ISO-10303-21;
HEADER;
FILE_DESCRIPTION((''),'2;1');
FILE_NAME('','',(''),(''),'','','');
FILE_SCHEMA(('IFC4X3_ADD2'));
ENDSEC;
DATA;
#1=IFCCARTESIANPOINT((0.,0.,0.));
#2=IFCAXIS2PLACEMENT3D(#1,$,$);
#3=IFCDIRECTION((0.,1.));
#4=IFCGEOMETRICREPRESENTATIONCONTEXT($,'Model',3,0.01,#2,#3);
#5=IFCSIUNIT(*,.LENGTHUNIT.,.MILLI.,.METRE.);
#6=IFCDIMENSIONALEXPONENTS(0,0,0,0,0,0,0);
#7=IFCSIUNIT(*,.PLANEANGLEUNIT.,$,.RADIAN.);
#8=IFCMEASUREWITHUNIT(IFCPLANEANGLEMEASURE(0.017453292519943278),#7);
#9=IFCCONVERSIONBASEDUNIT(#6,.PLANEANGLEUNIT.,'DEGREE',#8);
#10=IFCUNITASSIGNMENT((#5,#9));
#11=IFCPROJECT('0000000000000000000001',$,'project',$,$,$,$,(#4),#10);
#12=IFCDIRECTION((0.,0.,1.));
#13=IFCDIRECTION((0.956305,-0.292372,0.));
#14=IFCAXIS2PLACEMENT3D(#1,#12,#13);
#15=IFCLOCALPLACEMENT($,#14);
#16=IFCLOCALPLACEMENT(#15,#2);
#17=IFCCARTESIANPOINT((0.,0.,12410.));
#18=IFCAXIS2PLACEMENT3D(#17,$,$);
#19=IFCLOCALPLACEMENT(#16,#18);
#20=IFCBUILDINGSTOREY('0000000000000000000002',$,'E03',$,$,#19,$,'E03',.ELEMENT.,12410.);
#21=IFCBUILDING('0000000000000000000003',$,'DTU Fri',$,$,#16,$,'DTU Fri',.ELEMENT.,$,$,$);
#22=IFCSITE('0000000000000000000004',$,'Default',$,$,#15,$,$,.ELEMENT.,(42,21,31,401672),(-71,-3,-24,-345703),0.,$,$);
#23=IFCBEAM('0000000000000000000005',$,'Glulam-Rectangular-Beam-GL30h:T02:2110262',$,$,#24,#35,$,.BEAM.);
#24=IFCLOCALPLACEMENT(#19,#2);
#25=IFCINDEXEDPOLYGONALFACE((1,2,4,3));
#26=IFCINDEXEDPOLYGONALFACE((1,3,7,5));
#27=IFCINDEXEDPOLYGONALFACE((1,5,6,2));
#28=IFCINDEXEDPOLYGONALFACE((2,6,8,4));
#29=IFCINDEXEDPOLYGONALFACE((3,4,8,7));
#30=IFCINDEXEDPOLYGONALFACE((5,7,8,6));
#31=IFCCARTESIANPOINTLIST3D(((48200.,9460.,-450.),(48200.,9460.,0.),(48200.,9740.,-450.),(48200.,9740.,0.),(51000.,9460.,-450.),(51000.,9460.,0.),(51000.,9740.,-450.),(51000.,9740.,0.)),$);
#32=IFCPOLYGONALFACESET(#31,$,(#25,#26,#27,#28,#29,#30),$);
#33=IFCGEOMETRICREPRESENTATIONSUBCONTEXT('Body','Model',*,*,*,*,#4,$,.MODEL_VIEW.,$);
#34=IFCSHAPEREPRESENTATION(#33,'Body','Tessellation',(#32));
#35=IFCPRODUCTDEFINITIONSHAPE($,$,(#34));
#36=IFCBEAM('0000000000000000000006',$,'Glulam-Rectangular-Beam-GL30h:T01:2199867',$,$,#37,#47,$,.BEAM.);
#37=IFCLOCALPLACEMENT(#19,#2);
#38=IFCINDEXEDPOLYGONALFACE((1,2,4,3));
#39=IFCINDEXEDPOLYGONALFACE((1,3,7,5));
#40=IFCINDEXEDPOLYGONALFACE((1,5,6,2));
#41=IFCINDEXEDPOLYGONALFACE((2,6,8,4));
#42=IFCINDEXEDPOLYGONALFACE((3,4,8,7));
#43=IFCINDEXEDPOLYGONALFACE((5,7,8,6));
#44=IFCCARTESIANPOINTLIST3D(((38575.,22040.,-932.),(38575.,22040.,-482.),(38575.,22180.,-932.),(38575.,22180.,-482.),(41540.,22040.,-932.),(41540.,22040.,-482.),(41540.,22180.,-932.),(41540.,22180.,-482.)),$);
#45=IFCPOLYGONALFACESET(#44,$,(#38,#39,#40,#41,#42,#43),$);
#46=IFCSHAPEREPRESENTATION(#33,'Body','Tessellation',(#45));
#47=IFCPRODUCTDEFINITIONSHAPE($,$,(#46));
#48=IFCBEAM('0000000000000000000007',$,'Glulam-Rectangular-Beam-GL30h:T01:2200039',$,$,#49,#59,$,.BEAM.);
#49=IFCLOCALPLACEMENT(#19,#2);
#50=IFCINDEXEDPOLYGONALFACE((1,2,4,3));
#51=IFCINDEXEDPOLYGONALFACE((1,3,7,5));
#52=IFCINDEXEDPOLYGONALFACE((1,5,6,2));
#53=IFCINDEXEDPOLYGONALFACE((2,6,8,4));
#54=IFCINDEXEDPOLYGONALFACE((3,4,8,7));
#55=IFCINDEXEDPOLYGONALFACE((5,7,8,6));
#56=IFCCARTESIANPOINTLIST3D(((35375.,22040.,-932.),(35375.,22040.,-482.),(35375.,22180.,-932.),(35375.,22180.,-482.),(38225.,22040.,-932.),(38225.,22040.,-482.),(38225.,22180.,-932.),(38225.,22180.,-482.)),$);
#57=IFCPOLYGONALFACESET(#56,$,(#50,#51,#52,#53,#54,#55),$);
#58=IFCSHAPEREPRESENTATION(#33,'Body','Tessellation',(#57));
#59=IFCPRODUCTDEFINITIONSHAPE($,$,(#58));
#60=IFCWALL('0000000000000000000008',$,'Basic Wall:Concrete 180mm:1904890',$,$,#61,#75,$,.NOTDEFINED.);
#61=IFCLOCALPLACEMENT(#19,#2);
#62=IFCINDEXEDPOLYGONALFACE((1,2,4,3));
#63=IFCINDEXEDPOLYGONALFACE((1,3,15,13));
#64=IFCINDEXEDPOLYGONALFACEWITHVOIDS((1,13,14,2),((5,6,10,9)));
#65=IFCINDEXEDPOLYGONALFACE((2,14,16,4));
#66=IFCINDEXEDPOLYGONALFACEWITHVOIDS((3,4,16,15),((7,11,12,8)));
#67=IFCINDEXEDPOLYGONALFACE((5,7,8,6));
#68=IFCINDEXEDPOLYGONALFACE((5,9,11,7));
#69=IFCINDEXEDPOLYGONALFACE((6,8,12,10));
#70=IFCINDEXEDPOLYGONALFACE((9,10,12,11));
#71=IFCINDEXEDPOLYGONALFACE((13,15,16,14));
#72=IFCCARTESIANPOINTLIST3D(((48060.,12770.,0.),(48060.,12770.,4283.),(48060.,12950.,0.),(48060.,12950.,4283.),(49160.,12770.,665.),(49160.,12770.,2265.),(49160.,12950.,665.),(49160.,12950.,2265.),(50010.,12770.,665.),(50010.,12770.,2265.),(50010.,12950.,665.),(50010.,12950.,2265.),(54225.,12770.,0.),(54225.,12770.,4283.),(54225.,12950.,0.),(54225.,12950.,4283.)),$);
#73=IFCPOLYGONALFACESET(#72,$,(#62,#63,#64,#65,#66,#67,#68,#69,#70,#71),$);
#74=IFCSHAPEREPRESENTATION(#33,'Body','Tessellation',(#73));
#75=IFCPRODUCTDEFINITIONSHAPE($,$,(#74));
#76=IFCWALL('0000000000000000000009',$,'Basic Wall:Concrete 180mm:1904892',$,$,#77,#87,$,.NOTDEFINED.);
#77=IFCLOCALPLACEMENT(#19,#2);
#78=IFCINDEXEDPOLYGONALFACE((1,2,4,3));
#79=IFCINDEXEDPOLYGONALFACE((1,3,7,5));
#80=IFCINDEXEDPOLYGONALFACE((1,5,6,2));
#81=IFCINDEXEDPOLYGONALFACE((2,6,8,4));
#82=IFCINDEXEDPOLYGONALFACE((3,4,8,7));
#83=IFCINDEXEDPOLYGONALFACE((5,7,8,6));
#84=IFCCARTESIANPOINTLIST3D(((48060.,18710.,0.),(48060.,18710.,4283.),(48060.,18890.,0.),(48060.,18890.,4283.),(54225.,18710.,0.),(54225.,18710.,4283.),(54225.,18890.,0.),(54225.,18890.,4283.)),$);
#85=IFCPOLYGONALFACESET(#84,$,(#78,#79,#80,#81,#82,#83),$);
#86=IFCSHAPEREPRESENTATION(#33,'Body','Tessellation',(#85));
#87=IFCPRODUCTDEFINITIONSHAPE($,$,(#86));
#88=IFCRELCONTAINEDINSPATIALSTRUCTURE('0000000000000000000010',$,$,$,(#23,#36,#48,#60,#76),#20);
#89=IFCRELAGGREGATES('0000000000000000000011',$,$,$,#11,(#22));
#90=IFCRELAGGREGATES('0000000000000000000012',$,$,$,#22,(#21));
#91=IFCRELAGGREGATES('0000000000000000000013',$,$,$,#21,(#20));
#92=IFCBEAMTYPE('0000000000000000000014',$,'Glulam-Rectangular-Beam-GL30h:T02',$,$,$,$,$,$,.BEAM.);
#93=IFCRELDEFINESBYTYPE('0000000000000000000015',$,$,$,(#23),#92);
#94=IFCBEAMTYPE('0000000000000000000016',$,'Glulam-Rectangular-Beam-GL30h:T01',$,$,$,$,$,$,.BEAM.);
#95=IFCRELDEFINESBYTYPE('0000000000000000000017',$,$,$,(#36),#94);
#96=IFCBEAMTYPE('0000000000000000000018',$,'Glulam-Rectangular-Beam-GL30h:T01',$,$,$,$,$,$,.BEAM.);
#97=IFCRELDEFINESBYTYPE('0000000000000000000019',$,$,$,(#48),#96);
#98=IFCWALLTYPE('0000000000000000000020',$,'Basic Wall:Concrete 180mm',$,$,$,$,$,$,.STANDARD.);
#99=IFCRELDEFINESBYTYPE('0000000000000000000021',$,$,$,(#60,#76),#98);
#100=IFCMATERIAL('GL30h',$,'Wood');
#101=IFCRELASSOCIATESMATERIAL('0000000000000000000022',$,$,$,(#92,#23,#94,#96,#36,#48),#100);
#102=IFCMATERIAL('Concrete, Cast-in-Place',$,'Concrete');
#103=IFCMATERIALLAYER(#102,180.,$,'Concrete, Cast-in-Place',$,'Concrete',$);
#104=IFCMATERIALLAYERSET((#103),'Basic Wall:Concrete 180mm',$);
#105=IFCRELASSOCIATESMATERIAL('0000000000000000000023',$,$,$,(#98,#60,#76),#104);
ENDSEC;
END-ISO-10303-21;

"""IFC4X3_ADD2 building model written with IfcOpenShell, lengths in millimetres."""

from ifc_helpers import new_model, entity, si_unit, converted_unit, direction, frame, frame_2d, origin, origin_2d_with_axis, place, context, subcontext, project, spatial, rectangle, extrude, source, transform, mapped, material, layer, layer_set, material_profile, profile_set, profile_usage, type_object, type_shapes, element, save


model = new_model("IFC4X3_ADD2")

# Units and contexts
model_context = context("Model", 3, precision=0.01, world=origin(), true_north=direction((0.0, 1.0)))
body_context = subcontext(model_context, "Body", "Model", "MODEL_VIEW")
ifc_project = project(units=[si_unit("LENGTHUNIT", "METRE", prefix="MILLI"), converted_unit("PLANEANGLEUNIT", "DEGREE", entity("IfcPlaneAngleMeasure", 0.017453292519943278), si_unit("PLANEANGLEUNIT", "RADIAN"), dimensions=[0, 0, 0, 0, 0, 0, 0])], contexts=[model_context])

# Site, building, storey
site_placement = place(None, frame((0.0, 0.0, 0.0), z_axis=(0.0, 0.0, 1.0), x_axis=(0.956305, -0.292372, 0.0)))
site = spatial("IfcSite", under=ifc_project, at=site_placement, Name="Default", CompositionType="ELEMENT", RefLatitude=(42, 21, 31, 401672), RefLongitude=(-71, -3, -24, -345703), RefElevation=0.0)
building_placement = place(site_placement, origin())
building = spatial("IfcBuilding", under=site, at=building_placement, Name="DTU Fri", LongName="DTU Fri", CompositionType="ELEMENT")
storey_placement = place(building_placement, frame((0.0, 0.0, 12410.0)))
storey = spatial("IfcBuildingStorey", under=building, at=storey_placement, Name="E03", LongName="E03", CompositionType="ELEMENT", Elevation=12410.0)

# Shared definitions
ifc_material_1 = material(Name="GL30h", Category="Wood")

# Beams
ifc_material_profile_1 = material_profile(ifc_material_1, rectangle(XDim=450.0, YDim=280.0, at=origin_2d_with_axis()), Name="T02")
ifc_profile_set_1 = profile_set([ifc_material_profile_1], Name="T02")
ifc_profile_usage_1 = profile_usage(ifc_profile_set_1, cardinal=8)
ifc_material_profile_2 = material_profile(ifc_material_1, rectangle(XDim=450.0, YDim=140.0, at=origin_2d_with_axis()), Name="T01")
ifc_profile_set_2 = profile_set([ifc_material_profile_2], Name="T01")
ifc_profile_usage_2 = profile_usage(ifc_profile_set_2, cardinal=8)
beam_type_1 = type_object("IfcBeamType", Name="Glulam-Rectangular-Beam-GL30h:T02", PredefinedType="BEAM", material=ifc_profile_set_1)
shared_shape_1 = source(origin(), body_context, "Body", "SweptSolid", [
    extrude(rectangle(XDim=450.0, YDim=280.0, at=origin_2d_with_axis()), frame((-1412.5, 0.0, 0.0), z_axis=(1.0, 0.0, 0.0), x_axis=(0.0, 0.0, -1.0)), (0.0, 0.0, 1.0), 2800.0),
])
type_shapes(beam_type_1, [shared_shape_1])
beam_1_placement = place(storey_placement, frame((49612.5, 9600.0, -225.0)))
element("IfcBeam", 1, at=beam_1_placement, inside=storey, type_object=beam_type_1, material=ifc_profile_usage_1, Name="Glulam-Rectangular-Beam-GL30h:T02:2110262", PredefinedType="BEAM", context=body_context, shape_type="MappedRepresentation", body=[
    mapped(shared_shape_1, transform((0.0, 0.0, 0.0), scale=1.0)),
])
beam_type_2 = type_object("IfcBeamType", Name="Glulam-Rectangular-Beam-GL30h:T01", PredefinedType="BEAM", material=ifc_profile_set_2)
shared_shape_2 = source(origin(), body_context, "Body", "SweptSolid", [
    extrude(rectangle(XDim=450.0, YDim=140.0, at=origin_2d_with_axis()), frame((-1425.0, 0.0, 0.0), z_axis=(1.0, 0.0, 0.0), x_axis=(0.0, 0.0, -1.0)), (0.0, 0.0, 1.0), 2965.0),
])
type_shapes(beam_type_2, [shared_shape_2])
beam_2_placement = place(storey_placement, frame((40000.0, 22110.0, -707.0)))
element("IfcBeam", 2, at=beam_2_placement, inside=storey, type_object=beam_type_2, material=ifc_profile_usage_2, Name="Glulam-Rectangular-Beam-GL30h:T01:2199867", PredefinedType="BEAM", context=body_context, shape_type="MappedRepresentation", body=[
    mapped(shared_shape_2, transform((0.0, 0.0, 0.0), scale=1.0)),
])
beam_type_3 = type_object("IfcBeamType", Name="Glulam-Rectangular-Beam-GL30h:T01", PredefinedType="BEAM", material=ifc_profile_set_2)
shared_shape_3 = source(origin(), body_context, "Body", "SweptSolid", [
    extrude(rectangle(XDim=450.0, YDim=140.0, at=origin_2d_with_axis()), frame((-1425.0, 0.0, 0.0), z_axis=(1.0, 0.0, 0.0), x_axis=(0.0, 0.0, -1.0)), (0.0, 0.0, 1.0), 2850.0),
])
type_shapes(beam_type_3, [shared_shape_3])
beam_3_placement = place(storey_placement, frame((36800.0, 22110.0, -707.0)))
element("IfcBeam", 3, at=beam_3_placement, inside=storey, type_object=beam_type_3, material=ifc_profile_usage_2, Name="Glulam-Rectangular-Beam-GL30h:T01:2200039", PredefinedType="BEAM", context=body_context, shape_type="MappedRepresentation", body=[
    mapped(shared_shape_3, transform((0.0, 0.0, 0.0), scale=1.0)),
])

# Wall, opening
ifc_material_2 = material(Name="Concrete, Cast-in-Place", Category="Concrete")
ifc_layer = layer(ifc_material_2, 180.0, Name="Concrete, Cast-in-Place", Category="Concrete")
ifc_layer_set = layer_set([ifc_layer], Name="Basic Wall:Concrete 180mm")
wall_type = type_object("IfcWallType", Name="Basic Wall:Concrete 180mm", PredefinedType="STANDARD", material=ifc_layer_set)
wall_1_placement = place(storey_placement, frame((48060.0, 12860.0, 0.0)))
wall_1 = element("IfcWall", 4, at=wall_1_placement, inside=storey, type_object=wall_type, material=ifc_layer_set, Name="Basic Wall:Concrete 180mm:1904890", PredefinedType="NOTDEFINED", context=body_context, shape_type="SweptSolid", body=[
    extrude(rectangle(XDim=6165.0, YDim=180.0, at=frame_2d((3082.5, 0.0), x_axis=(-1.0, 0.0))), origin(), (0.0, 0.0, 1.0), 4283.0),
])
opening_placement = place(wall_1_placement, origin())
element("IfcOpeningElement", 5, at=opening_placement, cuts=wall_1, PredefinedType="OPENING", context=body_context, shape_type="SweptSolid", body=[
    extrude(rectangle(XDim=1600.0, YDim=850.0, at=frame_2d((0.0, 0.0), x_axis=(0.0, 1.0))), frame((1525.0, 90.0, 1465.0), z_axis=(0.0, -1.0, 0.0), x_axis=(1.0, 0.0, 0.0)), (0.0, 0.0, 1.0), 180.0),
])

# Wall
wall_2_placement = place(storey_placement, frame((48060.0, 18800.0, 0.0)))
element("IfcWall", 6, at=wall_2_placement, inside=storey, type_object=wall_type, material=ifc_layer_set, Name="Basic Wall:Concrete 180mm:1904892", PredefinedType="NOTDEFINED", context=body_context, shape_type="SweptSolid", body=[
    extrude(rectangle(XDim=6165.0, YDim=180.0, at=frame_2d((3082.5, 0.0), x_axis=(-1.0, 0.0))), origin(), (0.0, 0.0, 1.0), 4283.0),
])

save(model, "model.ifc")
